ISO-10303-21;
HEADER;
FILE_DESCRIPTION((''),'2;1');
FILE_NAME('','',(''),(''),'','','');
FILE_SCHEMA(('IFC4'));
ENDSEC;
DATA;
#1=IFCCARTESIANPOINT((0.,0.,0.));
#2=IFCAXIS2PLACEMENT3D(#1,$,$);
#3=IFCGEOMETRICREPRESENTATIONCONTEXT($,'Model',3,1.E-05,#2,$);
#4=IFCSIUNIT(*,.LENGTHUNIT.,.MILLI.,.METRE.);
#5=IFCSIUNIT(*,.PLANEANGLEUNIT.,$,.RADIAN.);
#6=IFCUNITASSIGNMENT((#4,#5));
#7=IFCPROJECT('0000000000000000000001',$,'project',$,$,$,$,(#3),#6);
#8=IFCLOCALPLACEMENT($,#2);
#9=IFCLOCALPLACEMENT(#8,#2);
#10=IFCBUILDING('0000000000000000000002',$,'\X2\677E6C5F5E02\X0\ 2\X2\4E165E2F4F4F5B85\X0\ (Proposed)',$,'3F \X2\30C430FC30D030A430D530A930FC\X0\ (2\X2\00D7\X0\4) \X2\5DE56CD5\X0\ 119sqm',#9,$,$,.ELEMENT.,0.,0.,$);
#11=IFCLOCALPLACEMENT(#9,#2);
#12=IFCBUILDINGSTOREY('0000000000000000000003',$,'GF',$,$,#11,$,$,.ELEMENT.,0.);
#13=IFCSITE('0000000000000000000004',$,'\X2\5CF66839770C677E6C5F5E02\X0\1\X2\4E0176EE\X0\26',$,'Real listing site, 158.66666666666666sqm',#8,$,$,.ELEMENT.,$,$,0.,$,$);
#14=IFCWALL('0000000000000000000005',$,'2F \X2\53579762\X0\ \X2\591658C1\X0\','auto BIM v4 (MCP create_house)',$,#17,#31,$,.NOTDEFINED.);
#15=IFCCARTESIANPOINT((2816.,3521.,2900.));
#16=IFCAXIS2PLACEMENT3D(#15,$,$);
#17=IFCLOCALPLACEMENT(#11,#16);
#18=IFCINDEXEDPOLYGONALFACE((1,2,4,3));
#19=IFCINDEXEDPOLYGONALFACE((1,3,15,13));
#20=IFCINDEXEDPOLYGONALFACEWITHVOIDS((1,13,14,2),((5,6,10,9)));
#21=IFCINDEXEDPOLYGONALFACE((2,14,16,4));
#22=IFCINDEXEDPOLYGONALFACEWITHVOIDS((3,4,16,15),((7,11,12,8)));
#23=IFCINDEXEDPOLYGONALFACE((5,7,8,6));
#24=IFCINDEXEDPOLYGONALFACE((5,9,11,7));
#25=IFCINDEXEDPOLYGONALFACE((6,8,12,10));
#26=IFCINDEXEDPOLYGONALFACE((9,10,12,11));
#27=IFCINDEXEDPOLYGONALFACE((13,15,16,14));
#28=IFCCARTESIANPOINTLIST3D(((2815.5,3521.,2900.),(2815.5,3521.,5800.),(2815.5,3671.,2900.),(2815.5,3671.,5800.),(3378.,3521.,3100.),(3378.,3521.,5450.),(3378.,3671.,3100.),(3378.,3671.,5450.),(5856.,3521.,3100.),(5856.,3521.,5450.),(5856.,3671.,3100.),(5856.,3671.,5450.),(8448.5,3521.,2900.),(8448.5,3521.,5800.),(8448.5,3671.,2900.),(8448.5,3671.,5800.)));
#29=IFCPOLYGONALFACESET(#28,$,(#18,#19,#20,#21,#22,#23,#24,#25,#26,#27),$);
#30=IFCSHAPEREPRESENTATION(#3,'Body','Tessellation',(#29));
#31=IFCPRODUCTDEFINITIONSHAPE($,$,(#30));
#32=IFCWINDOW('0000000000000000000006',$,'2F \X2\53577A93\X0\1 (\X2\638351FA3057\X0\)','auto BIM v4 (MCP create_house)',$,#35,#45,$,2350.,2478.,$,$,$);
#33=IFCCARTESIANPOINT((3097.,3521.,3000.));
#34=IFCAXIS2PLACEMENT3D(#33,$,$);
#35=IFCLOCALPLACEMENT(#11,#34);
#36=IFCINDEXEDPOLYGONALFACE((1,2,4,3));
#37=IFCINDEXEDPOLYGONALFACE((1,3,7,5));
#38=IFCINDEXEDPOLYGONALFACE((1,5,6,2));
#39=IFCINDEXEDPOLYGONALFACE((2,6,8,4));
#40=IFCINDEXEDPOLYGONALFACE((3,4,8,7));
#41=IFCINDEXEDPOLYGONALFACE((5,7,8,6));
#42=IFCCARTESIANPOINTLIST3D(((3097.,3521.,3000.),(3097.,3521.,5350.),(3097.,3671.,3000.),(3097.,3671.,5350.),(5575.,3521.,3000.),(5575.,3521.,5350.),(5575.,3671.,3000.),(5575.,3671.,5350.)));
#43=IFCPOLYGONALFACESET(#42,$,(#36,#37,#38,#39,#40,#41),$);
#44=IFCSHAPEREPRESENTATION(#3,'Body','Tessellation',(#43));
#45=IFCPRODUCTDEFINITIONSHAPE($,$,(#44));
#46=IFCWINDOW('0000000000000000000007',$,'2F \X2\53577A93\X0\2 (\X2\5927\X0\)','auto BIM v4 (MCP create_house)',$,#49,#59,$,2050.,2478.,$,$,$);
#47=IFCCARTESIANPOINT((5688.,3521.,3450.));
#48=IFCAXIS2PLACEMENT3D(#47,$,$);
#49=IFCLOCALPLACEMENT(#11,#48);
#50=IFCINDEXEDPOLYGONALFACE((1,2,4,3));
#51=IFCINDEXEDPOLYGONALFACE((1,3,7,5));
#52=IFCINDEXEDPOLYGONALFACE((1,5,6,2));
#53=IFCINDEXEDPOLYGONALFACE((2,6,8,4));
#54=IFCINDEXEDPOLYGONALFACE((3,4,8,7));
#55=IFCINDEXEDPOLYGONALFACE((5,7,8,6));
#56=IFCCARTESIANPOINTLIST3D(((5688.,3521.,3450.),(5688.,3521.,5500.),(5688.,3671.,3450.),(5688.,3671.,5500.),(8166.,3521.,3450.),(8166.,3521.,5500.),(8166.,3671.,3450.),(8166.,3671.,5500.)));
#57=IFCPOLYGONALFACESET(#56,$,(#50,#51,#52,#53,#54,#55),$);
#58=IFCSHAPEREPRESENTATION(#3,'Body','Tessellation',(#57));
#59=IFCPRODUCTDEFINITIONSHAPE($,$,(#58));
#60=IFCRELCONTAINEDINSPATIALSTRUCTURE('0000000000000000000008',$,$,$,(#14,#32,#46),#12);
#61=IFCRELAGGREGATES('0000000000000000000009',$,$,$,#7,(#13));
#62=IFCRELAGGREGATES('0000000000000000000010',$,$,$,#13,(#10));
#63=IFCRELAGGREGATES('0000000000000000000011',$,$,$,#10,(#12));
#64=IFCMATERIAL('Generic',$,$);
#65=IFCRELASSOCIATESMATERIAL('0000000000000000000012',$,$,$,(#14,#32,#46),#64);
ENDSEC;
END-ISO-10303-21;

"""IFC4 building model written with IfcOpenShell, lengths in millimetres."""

from ifc_helpers import new_model, si_unit, frame, frame_2d, origin, place, context, project, spatial, rectangle, extrude, material, element, fill, save


model = new_model("IFC4")

# Units and contexts
model_context = context("Model", 3, precision=1e-05, world=origin())
ifc_project = project(units=[si_unit("LENGTHUNIT", "METRE", prefix="MILLI"), si_unit("PLANEANGLEUNIT", "RADIAN")], contexts=[model_context])

# Site, building, storey
site_placement = place(None, origin())
site = spatial("IfcSite", under=ifc_project, at=site_placement, Name="島根県松江市1丁目26", ObjectType="Real listing site, 158.66666666666666sqm", CompositionType="ELEMENT", RefElevation=0.0)
building_placement = place(site_placement, origin())
building = spatial("IfcBuilding", under=site, at=building_placement, Name="松江市 2世帯住宅 (Proposed)", ObjectType="3F ツーバイフォー (2×4) 工法 119sqm", CompositionType="ELEMENT", ElevationOfRefHeight=0.0, ElevationOfTerrain=0.0)
storey_placement = place(building_placement, origin())
storey = spatial("IfcBuildingStorey", under=building, at=storey_placement, Name="GF", CompositionType="ELEMENT", Elevation=0.0)

# Shared definitions
ifc_material = material(Name="Generic")

# Wall, openings, windows
wall_1_placement = place(storey_placement, frame((2816.0, 3521.0, 2900.0)))
wall_1 = element("IfcWall", 1, at=wall_1_placement, inside=storey, material=ifc_material, Name="2F 南面 外壁", Description="auto BIM v4 (MCP create_house)", PredefinedType="NOTDEFINED", context=model_context, shape_type="SweptSolid", body=[
    extrude(rectangle(XDim=5633.0, YDim=150.0, at=frame_2d((2816.0, 75.0))), frame((2816.0, 3521.0, 2900.0)), (0.0, 0.0, 1.0), 2900.0),
])
opening_1_placement = place(storey_placement, frame((3097.0, 3521.0, 3000.0)))
opening_1 = element("IfcOpeningElement", 2, at=opening_1_placement, cuts=wall_1, PredefinedType="NOTDEFINED", context=model_context, shape_type="SweptSolid", body=[
    extrude(rectangle(XDim=2478.0, YDim=150.0, at=frame_2d((1239.0, 75.0))), frame((3097.0, 3521.0, 3000.0)), (0.0, 0.0, 1.0), 2350.0),
])
opening_2_placement = place(storey_placement, frame((5688.0, 3521.0, 3450.0)))
opening_2 = element("IfcOpeningElement", 3, at=opening_2_placement, cuts=wall_1, PredefinedType="NOTDEFINED", context=model_context, shape_type="SweptSolid", body=[
    extrude(rectangle(XDim=2478.0, YDim=150.0, at=frame_2d((1239.0, 75.0))), frame((5688.0, 3521.0, 3450.0)), (0.0, 0.0, 1.0), 2050.0),
])
window_1_placement = place(storey_placement, frame((3097.0, 3521.0, 3000.0)))
window_1 = element("IfcWindow", 4, at=window_1_placement, inside=storey, material=ifc_material, Name="2F 南窓1 (掃出し)", Description="auto BIM v4 (MCP create_house)", OverallHeight=2350.0, OverallWidth=2478.0, context=model_context, shape_type="SweptSolid", body=[
    extrude(rectangle(XDim=2478.0, YDim=150.0, at=frame_2d((1239.0, 75.0))), frame((3097.0, 3521.0, 3000.0)), (0.0, 0.0, 1.0), 2350.0),
])
fill(opening_1, window_1)
window_2_placement = place(storey_placement, frame((5688.0, 3521.0, 3450.0)))
window_2 = element("IfcWindow", 5, at=window_2_placement, inside=storey, material=ifc_material, Name="2F 南窓2 (大)", Description="auto BIM v4 (MCP create_house)", OverallHeight=2050.0, OverallWidth=2478.0, context=model_context, shape_type="SweptSolid", body=[
    extrude(rectangle(XDim=2478.0, YDim=150.0, at=frame_2d((1239.0, 75.0))), frame((5688.0, 3521.0, 3450.0)), (0.0, 0.0, 1.0), 2050.0),
])
fill(opening_2, window_2)

save(model, "model.ifc")
